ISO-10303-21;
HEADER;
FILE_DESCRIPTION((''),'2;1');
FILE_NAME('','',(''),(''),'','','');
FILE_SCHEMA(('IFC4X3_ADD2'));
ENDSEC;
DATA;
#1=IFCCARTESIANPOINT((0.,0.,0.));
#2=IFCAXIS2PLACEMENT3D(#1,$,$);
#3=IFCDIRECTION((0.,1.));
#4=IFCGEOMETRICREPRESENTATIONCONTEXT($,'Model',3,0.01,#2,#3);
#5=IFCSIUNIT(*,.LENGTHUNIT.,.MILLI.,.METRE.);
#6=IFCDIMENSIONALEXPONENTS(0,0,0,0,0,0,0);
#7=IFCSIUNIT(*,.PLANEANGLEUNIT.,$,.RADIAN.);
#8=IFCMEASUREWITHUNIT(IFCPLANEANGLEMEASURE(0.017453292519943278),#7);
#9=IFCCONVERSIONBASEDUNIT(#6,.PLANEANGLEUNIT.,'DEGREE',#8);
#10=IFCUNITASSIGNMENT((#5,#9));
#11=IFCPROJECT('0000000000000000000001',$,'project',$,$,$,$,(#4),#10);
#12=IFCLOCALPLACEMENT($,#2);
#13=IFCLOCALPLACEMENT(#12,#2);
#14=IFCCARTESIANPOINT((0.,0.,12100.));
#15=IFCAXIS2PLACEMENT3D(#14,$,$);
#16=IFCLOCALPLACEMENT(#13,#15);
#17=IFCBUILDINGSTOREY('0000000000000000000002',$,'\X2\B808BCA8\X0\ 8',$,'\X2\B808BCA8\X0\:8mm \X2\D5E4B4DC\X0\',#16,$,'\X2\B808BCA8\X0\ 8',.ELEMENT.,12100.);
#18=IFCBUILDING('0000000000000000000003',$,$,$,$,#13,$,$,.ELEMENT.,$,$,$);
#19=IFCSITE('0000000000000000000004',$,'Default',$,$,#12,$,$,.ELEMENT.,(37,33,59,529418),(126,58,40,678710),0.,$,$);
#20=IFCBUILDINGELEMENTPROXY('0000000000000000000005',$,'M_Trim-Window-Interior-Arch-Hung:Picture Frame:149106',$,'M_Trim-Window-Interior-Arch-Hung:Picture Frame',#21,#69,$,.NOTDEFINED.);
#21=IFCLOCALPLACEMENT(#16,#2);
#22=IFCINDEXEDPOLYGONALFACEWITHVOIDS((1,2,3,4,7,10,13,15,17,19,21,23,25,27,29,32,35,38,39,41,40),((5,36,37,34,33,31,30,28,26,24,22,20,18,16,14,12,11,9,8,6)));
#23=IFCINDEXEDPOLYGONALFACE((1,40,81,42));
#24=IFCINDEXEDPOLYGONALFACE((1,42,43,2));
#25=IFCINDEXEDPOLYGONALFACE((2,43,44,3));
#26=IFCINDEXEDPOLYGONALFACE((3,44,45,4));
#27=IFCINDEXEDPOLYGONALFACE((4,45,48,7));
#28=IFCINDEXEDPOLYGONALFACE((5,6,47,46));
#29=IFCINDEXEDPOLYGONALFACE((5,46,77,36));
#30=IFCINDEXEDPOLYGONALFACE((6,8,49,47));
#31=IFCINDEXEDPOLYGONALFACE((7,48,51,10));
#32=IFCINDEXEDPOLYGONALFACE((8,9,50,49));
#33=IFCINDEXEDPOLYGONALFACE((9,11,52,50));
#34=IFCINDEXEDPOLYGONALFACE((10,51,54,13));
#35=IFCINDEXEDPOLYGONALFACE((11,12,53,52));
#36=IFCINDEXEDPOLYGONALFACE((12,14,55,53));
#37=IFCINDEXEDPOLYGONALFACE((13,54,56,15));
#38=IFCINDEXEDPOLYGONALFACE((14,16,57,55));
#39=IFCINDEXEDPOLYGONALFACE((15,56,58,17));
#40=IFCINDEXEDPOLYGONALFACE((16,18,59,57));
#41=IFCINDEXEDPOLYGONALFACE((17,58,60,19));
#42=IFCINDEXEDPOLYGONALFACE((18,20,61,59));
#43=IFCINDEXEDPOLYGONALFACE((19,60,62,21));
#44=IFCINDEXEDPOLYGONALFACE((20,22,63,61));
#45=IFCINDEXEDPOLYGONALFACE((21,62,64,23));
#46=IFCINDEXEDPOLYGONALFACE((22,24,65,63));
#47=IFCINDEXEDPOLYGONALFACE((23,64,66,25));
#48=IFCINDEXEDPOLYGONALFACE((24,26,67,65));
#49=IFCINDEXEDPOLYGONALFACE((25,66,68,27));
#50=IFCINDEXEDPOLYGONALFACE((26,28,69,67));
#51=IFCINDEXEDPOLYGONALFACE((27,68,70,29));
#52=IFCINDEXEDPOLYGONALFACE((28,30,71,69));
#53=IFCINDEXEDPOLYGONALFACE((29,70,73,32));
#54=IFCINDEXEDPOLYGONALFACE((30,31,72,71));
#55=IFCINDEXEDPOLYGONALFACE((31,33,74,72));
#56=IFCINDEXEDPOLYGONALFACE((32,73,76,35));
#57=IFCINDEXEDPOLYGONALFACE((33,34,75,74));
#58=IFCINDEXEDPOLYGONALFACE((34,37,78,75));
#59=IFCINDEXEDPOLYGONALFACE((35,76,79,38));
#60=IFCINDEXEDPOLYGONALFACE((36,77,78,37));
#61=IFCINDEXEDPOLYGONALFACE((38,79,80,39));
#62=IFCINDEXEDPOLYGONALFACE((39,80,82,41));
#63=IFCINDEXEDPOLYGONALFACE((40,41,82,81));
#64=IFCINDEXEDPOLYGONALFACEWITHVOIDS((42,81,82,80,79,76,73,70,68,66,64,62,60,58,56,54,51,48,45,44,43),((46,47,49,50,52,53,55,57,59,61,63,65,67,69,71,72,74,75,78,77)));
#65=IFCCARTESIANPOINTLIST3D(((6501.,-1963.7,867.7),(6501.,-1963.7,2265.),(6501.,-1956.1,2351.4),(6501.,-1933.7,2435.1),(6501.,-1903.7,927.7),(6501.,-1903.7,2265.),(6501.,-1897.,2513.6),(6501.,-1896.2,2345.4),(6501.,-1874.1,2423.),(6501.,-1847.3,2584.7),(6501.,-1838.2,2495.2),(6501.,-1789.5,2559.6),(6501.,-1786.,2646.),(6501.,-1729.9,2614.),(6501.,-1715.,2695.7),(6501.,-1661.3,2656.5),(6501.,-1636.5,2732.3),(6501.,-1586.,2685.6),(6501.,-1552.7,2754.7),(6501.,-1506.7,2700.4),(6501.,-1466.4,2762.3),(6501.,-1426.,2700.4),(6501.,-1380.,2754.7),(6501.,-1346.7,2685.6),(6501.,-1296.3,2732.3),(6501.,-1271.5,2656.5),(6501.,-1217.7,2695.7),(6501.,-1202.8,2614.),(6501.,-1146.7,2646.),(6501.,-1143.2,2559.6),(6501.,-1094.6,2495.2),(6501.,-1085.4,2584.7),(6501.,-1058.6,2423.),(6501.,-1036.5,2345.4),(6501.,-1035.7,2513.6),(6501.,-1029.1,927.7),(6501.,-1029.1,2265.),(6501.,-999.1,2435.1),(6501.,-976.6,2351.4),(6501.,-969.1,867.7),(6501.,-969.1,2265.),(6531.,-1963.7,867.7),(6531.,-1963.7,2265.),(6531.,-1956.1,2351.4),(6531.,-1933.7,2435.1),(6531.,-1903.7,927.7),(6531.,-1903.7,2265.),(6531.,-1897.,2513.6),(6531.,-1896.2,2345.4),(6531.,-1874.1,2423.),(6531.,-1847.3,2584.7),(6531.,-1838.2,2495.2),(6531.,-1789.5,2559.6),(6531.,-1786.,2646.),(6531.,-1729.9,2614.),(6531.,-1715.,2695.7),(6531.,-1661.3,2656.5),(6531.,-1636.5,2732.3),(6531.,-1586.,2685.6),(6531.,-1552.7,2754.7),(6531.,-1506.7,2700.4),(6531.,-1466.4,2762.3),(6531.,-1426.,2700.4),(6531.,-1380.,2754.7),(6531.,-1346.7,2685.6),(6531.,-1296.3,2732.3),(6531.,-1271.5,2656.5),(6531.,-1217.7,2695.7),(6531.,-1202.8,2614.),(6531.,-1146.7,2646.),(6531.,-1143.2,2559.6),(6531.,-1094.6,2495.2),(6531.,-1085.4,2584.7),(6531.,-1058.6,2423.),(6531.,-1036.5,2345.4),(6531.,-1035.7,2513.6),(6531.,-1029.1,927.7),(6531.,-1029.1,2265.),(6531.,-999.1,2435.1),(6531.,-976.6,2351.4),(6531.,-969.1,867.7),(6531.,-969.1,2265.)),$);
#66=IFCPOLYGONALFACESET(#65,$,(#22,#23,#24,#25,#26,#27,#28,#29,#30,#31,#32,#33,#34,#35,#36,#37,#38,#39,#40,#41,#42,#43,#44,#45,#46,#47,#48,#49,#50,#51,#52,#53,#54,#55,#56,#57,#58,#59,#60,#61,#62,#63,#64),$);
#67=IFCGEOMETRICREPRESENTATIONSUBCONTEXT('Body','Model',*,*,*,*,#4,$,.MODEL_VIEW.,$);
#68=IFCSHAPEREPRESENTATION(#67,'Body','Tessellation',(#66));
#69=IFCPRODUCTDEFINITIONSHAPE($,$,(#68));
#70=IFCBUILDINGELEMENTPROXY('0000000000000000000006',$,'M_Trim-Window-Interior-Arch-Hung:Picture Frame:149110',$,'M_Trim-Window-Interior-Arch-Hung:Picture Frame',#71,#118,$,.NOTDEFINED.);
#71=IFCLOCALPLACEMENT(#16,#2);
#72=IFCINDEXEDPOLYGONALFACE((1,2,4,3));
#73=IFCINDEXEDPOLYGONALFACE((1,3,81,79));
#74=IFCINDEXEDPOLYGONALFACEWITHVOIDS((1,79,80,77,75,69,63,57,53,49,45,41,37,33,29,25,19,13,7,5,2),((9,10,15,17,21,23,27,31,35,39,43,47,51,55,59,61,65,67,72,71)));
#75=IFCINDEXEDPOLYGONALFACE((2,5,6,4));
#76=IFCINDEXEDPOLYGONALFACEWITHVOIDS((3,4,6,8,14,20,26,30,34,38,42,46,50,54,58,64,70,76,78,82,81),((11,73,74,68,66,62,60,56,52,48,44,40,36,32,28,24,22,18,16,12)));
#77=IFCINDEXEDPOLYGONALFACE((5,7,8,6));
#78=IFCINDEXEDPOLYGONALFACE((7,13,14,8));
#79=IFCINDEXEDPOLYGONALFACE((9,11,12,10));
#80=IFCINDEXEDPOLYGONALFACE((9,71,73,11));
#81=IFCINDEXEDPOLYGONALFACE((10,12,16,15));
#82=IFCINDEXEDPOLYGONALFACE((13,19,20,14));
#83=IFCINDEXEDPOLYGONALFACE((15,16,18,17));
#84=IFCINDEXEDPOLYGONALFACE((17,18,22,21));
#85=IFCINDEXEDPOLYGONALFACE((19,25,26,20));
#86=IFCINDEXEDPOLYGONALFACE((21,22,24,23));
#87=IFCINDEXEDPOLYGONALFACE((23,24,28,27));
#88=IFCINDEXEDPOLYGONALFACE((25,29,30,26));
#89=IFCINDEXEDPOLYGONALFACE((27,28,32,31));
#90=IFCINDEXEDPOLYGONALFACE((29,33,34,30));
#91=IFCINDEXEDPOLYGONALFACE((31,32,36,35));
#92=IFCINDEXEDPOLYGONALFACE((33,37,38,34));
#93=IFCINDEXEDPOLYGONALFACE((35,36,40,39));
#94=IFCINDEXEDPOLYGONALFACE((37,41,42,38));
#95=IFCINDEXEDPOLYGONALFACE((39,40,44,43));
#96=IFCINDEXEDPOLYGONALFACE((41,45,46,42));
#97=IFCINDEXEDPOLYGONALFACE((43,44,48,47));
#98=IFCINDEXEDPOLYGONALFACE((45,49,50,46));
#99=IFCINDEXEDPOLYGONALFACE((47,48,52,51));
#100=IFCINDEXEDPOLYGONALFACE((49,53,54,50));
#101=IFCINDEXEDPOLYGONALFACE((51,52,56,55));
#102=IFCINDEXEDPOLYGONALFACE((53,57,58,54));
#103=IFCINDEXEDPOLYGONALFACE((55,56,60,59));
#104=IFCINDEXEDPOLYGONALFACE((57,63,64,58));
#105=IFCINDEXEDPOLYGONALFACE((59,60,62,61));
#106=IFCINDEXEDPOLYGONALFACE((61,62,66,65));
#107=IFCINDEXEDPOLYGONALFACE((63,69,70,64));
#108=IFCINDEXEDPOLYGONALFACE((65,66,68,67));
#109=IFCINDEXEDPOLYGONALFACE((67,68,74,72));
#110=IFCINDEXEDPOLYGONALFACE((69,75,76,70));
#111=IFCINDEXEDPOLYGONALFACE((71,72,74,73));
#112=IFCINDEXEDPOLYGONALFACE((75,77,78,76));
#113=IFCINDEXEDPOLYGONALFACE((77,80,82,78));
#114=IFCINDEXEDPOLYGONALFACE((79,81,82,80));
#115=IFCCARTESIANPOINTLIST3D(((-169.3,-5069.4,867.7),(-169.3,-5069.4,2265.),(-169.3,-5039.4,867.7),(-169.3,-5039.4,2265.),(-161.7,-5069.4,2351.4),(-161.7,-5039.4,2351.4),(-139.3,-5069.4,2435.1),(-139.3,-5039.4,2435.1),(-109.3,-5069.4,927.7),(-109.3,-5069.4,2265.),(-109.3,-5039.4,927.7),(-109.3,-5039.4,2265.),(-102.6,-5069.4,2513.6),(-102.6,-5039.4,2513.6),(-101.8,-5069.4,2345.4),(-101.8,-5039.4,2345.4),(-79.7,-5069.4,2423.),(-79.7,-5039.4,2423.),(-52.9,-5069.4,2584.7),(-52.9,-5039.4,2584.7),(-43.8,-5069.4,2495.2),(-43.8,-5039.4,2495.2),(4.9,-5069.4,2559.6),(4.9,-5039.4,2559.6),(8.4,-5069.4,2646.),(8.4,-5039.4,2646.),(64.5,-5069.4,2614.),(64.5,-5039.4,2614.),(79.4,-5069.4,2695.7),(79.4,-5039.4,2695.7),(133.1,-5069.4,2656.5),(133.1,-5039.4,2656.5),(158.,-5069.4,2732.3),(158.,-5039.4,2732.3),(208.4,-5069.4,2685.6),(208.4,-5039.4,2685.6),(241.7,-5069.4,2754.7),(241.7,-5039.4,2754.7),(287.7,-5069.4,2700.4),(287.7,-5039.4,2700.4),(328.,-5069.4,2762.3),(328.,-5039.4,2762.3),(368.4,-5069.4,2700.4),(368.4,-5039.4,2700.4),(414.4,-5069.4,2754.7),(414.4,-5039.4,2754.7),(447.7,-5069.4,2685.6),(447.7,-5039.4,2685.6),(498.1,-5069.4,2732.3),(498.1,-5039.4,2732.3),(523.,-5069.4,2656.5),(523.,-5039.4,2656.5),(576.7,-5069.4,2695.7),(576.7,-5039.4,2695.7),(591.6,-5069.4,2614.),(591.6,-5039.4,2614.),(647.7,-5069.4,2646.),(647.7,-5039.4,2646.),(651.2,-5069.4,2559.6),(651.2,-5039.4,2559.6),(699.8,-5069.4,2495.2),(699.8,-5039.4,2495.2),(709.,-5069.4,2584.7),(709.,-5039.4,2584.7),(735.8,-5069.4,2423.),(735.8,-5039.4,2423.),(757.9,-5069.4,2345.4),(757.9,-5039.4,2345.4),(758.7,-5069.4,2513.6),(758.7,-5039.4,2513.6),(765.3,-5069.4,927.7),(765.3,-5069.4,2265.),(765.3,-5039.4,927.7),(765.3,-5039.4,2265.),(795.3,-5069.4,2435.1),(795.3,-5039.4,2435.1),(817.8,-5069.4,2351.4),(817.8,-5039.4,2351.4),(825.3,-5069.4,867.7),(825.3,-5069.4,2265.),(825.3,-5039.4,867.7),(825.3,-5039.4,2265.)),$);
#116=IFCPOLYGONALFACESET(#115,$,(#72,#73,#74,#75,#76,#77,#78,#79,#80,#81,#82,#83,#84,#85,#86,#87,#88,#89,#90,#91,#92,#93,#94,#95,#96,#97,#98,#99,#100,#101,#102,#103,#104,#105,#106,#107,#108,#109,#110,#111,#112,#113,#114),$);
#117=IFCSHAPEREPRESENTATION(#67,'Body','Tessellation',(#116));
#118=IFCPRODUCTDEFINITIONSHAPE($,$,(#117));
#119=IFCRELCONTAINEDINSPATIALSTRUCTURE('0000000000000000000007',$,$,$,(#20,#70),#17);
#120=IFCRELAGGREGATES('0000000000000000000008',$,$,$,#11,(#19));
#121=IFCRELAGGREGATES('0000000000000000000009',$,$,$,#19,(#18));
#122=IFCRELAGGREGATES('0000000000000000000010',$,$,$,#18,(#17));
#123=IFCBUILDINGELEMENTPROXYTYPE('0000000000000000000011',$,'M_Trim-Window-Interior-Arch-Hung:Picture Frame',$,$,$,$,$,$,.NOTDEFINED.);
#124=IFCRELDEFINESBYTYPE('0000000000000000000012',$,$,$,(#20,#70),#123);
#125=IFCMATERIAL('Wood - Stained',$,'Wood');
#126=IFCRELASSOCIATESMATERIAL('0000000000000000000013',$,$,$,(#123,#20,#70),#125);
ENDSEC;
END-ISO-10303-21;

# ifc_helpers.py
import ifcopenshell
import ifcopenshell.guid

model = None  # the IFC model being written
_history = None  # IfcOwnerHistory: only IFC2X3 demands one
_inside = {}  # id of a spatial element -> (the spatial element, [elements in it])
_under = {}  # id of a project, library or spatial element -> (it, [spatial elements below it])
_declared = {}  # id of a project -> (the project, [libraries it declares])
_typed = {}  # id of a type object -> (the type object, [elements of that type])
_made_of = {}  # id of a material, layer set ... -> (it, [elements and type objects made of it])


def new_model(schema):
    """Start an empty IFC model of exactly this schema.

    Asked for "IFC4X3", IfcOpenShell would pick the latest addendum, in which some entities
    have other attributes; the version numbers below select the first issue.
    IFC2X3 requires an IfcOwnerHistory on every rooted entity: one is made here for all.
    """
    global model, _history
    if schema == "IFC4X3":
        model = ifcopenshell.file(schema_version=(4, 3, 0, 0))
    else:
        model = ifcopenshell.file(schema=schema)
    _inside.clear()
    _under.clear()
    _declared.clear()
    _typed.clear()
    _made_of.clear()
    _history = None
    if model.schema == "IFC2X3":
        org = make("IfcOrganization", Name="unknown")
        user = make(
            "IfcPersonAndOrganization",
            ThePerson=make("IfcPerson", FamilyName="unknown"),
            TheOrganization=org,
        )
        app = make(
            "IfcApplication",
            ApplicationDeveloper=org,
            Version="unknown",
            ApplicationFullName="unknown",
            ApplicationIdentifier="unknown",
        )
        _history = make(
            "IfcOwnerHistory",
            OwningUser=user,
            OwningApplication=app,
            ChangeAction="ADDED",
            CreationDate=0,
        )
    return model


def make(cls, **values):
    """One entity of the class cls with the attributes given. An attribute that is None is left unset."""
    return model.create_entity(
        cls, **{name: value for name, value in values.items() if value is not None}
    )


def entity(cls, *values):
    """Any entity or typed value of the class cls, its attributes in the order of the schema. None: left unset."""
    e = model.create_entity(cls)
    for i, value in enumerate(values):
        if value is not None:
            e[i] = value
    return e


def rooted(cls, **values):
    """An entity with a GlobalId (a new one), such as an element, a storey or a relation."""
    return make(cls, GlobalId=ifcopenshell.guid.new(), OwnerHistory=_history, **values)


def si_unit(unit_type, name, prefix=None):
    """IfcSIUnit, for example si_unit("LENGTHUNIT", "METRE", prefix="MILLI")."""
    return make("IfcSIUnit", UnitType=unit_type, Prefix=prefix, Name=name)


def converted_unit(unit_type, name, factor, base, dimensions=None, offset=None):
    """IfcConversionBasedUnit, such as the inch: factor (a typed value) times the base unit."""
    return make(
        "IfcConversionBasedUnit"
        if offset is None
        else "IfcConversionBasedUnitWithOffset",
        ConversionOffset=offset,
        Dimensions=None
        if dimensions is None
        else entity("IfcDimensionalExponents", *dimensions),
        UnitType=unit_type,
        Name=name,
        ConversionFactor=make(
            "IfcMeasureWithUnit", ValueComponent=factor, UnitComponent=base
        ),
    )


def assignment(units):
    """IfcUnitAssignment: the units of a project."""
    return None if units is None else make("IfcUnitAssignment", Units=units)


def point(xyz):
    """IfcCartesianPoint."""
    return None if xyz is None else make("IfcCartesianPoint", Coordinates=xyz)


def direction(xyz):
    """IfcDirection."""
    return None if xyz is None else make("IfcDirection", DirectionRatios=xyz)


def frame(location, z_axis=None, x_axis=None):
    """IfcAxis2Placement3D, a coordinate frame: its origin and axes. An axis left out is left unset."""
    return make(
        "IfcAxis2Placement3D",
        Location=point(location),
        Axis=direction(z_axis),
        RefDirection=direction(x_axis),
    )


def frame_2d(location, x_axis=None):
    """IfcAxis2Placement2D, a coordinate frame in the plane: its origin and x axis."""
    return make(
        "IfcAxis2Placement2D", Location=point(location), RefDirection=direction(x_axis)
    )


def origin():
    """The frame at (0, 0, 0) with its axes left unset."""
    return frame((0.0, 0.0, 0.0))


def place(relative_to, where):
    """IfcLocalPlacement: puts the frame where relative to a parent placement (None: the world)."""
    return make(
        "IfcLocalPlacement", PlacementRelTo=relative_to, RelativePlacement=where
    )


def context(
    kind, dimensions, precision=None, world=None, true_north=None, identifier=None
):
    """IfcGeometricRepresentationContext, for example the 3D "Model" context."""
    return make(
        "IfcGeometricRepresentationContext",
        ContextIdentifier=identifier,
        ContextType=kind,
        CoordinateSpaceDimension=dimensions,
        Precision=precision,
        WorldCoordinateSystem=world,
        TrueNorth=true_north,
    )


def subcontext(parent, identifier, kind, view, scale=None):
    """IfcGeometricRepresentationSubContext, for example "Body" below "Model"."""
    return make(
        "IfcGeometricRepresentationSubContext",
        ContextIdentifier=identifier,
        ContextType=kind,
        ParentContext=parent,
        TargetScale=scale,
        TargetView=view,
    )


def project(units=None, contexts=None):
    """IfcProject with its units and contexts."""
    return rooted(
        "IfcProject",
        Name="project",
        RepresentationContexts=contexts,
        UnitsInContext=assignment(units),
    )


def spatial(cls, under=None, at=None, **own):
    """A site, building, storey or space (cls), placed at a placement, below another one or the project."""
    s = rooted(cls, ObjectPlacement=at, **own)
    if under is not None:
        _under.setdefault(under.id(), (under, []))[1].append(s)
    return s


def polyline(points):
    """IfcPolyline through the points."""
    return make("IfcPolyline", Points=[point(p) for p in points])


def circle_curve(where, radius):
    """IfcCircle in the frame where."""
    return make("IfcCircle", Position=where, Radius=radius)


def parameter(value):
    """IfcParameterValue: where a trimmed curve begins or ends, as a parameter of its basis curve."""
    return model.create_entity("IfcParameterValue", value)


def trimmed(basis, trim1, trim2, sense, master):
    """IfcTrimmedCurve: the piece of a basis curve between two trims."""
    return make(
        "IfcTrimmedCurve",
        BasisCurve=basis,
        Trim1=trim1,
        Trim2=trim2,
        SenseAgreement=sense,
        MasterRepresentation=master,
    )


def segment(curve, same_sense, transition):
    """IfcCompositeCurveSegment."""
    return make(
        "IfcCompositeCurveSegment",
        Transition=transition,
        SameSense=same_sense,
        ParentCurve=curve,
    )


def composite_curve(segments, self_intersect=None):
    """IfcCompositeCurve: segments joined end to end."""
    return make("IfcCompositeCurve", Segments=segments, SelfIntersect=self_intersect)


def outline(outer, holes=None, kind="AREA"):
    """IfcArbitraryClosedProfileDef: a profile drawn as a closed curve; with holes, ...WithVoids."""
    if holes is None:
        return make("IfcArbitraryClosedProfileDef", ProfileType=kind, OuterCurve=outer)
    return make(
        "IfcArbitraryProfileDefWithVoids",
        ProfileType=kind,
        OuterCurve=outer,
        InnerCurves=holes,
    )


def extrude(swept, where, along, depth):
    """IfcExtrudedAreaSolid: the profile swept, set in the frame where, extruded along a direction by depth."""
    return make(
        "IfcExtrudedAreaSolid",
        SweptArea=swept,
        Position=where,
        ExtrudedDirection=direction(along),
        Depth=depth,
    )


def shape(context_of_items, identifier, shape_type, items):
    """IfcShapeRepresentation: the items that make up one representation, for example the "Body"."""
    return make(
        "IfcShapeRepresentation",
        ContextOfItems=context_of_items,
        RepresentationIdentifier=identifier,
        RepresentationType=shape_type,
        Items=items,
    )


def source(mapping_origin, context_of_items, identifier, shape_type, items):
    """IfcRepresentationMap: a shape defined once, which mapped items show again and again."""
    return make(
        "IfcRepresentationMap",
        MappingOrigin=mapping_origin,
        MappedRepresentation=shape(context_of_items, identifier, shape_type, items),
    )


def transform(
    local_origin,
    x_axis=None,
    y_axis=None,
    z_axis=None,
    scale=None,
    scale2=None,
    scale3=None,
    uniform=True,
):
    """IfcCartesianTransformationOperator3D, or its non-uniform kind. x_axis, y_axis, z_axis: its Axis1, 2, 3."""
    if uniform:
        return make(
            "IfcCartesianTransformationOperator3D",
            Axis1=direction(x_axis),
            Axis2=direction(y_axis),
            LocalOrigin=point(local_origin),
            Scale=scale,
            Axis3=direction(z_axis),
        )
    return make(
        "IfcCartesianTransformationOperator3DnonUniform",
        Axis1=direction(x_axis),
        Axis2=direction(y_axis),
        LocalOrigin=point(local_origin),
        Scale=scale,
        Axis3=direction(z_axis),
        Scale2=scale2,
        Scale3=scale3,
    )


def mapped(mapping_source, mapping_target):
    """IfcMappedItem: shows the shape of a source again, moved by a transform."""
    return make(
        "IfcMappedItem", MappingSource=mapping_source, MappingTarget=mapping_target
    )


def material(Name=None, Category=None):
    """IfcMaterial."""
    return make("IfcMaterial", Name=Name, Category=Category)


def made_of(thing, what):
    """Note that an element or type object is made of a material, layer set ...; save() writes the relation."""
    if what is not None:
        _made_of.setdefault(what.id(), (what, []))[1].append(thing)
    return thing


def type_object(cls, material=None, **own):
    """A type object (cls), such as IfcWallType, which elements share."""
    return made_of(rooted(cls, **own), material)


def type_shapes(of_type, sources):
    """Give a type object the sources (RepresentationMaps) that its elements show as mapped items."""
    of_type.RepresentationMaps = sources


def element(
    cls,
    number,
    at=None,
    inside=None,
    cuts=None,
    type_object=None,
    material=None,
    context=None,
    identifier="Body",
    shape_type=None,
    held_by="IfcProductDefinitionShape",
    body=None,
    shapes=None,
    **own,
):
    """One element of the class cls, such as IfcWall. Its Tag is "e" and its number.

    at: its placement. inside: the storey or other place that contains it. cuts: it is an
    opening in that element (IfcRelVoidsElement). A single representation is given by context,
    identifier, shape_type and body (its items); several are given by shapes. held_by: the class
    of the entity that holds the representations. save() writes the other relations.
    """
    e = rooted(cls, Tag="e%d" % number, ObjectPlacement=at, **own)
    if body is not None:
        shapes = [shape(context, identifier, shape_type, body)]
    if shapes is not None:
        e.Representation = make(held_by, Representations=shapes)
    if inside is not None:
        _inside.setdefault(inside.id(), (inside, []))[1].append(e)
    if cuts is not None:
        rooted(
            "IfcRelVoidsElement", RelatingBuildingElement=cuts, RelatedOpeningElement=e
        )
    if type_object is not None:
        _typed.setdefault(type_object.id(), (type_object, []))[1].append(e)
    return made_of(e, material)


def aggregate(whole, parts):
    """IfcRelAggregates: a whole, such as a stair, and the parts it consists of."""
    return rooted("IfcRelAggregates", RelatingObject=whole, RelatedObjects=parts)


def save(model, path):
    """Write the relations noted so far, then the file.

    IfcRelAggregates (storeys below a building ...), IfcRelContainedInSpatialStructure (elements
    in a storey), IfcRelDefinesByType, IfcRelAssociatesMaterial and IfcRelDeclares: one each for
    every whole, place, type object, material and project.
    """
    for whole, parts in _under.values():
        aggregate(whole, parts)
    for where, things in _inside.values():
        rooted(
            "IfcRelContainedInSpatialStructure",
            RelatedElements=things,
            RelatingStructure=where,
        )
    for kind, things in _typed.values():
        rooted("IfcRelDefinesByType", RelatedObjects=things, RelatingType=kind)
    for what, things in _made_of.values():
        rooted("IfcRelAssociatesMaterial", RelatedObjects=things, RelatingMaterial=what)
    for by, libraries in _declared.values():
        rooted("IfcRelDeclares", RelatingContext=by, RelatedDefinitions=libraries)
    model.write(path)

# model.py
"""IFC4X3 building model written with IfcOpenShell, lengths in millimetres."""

from ifc_helpers import new_model, entity, si_unit, converted_unit, direction, frame, frame_2d, origin, place, context, subcontext, project, spatial, polyline, circle_curve, parameter, trimmed, segment, composite_curve, outline, extrude, source, transform, mapped, material, type_object, type_shapes, element, save


model = new_model("IFC4X3")

# Units and contexts
model_context = context("Model", 3, precision=0.01, world=origin(), true_north=direction((0.0, 1.0)))
body_context = subcontext(model_context, "Body", "Model", "MODEL_VIEW")
ifc_project = project(units=[si_unit("LENGTHUNIT", "METRE", prefix="MILLI"), converted_unit("PLANEANGLEUNIT", "DEGREE", entity("IfcPlaneAngleMeasure", 0.017453292519943278), si_unit("PLANEANGLEUNIT", "RADIAN"), dimensions=[0, 0, 0, 0, 0, 0, 0])], contexts=[model_context])

# Site, building, storey
site_placement = place(None, origin())
site = spatial("IfcSite", under=ifc_project, at=site_placement, Name="Default", CompositionType="ELEMENT", RefLatitude=(37, 33, 59, 529418), RefLongitude=(126, 58, 40, 678710), RefElevation=0.0)
building_placement = place(site_placement, origin())
building = spatial("IfcBuilding", under=site, at=building_placement, CompositionType="ELEMENT")
storey_placement = place(building_placement, frame((0.0, 0.0, 12100.0)))
storey = spatial("IfcBuildingStorey", under=building, at=storey_placement, Name="레벨 8", ObjectType="레벨:8mm 헤드", LongName="레벨 8", CompositionType="ELEMENT", Elevation=12100.0)

# Building element proxies
ifc_material_1 = material(Name="Wood - Stained", Category="Wood")
building_element_proxy_type_1 = type_object("IfcBuildingElementProxyType", Name="M_Trim-Window-Interior-Arch-Hung:Picture Frame", PredefinedType="NOTDEFINED", material=ifc_material_1)
shared_shape_1 = source(origin(), body_context, "Body", "SweptSolid", [
    extrude(outline(composite_curve([segment(polyline([(-698.7, -497.3), (698.7, -497.3)]), True, "CONTINUOUS"), segment(polyline([(698.7, -497.3), (698.7, 497.3)]), True, "CONTINUOUS"), segment(polyline([(698.7, 497.3), (-698.7, 497.3)]), True, "CONTINUOUS"), segment(trimmed(circle_curve(frame_2d((-698.7, 0.0), x_axis=(0.0, 1.0)), 497.3), [parameter(0.0)], [parameter(180.0)], True, "PARAMETER"), True, "CONTINUOUS")], self_intersect=False), holes=[composite_curve([segment(trimmed(circle_curve(frame_2d((-698.7, 0.0), x_axis=(0.0, 1.0)), 437.3), [parameter(0.0)], [parameter(180.0)], True, "PARAMETER"), False, "CONTINUOUS"), segment(polyline([(-698.7, 437.3), (638.6, 437.3)]), True, "CONTINUOUS"), segment(polyline([(638.6, 437.3), (638.7, -437.3)]), True, "CONTINUOUS"), segment(polyline([(638.7, -437.3), (-698.7, -437.3)]), True, "CONTINUOUS")], self_intersect=False)]), frame((0.0, -1148.7, 0.0), z_axis=(0.0, 0.0, 1.0), x_axis=(0.0, -1.0, 0.0)), (0.0, 0.0, 1.0), 30.0),
])
type_shapes(building_element_proxy_type_1, [shared_shape_1])
for number, where, z_axis, x_axis, name in (
    (1, (6531.0, -1466.4, 2715.0), (-1.0, 0.0, 0.0), (0.0, -1.0, 0.0), "M_Trim-Window-Interior-Arch-Hung:Picture Frame:149106"),
    (2, (328.0, -5069.4, 2715.0), (0.0, 1.0, 0.0), (-1.0, 0.0, 0.0), "M_Trim-Window-Interior-Arch-Hung:Picture Frame:149110"),
):
    element("IfcBuildingElementProxy", number, at=place(storey_placement, frame(where, z_axis=z_axis, x_axis=x_axis)), inside=storey, type_object=building_element_proxy_type_1, material=ifc_material_1, Name=name, ObjectType="M_Trim-Window-Interior-Arch-Hung:Picture Frame", PredefinedType="NOTDEFINED", context=body_context, shape_type="MappedRepresentation", body=[
        mapped(shared_shape_1, transform((0.0, 0.0, 0.0), scale=1.0)),
    ])

save(model, "model.ifc")
